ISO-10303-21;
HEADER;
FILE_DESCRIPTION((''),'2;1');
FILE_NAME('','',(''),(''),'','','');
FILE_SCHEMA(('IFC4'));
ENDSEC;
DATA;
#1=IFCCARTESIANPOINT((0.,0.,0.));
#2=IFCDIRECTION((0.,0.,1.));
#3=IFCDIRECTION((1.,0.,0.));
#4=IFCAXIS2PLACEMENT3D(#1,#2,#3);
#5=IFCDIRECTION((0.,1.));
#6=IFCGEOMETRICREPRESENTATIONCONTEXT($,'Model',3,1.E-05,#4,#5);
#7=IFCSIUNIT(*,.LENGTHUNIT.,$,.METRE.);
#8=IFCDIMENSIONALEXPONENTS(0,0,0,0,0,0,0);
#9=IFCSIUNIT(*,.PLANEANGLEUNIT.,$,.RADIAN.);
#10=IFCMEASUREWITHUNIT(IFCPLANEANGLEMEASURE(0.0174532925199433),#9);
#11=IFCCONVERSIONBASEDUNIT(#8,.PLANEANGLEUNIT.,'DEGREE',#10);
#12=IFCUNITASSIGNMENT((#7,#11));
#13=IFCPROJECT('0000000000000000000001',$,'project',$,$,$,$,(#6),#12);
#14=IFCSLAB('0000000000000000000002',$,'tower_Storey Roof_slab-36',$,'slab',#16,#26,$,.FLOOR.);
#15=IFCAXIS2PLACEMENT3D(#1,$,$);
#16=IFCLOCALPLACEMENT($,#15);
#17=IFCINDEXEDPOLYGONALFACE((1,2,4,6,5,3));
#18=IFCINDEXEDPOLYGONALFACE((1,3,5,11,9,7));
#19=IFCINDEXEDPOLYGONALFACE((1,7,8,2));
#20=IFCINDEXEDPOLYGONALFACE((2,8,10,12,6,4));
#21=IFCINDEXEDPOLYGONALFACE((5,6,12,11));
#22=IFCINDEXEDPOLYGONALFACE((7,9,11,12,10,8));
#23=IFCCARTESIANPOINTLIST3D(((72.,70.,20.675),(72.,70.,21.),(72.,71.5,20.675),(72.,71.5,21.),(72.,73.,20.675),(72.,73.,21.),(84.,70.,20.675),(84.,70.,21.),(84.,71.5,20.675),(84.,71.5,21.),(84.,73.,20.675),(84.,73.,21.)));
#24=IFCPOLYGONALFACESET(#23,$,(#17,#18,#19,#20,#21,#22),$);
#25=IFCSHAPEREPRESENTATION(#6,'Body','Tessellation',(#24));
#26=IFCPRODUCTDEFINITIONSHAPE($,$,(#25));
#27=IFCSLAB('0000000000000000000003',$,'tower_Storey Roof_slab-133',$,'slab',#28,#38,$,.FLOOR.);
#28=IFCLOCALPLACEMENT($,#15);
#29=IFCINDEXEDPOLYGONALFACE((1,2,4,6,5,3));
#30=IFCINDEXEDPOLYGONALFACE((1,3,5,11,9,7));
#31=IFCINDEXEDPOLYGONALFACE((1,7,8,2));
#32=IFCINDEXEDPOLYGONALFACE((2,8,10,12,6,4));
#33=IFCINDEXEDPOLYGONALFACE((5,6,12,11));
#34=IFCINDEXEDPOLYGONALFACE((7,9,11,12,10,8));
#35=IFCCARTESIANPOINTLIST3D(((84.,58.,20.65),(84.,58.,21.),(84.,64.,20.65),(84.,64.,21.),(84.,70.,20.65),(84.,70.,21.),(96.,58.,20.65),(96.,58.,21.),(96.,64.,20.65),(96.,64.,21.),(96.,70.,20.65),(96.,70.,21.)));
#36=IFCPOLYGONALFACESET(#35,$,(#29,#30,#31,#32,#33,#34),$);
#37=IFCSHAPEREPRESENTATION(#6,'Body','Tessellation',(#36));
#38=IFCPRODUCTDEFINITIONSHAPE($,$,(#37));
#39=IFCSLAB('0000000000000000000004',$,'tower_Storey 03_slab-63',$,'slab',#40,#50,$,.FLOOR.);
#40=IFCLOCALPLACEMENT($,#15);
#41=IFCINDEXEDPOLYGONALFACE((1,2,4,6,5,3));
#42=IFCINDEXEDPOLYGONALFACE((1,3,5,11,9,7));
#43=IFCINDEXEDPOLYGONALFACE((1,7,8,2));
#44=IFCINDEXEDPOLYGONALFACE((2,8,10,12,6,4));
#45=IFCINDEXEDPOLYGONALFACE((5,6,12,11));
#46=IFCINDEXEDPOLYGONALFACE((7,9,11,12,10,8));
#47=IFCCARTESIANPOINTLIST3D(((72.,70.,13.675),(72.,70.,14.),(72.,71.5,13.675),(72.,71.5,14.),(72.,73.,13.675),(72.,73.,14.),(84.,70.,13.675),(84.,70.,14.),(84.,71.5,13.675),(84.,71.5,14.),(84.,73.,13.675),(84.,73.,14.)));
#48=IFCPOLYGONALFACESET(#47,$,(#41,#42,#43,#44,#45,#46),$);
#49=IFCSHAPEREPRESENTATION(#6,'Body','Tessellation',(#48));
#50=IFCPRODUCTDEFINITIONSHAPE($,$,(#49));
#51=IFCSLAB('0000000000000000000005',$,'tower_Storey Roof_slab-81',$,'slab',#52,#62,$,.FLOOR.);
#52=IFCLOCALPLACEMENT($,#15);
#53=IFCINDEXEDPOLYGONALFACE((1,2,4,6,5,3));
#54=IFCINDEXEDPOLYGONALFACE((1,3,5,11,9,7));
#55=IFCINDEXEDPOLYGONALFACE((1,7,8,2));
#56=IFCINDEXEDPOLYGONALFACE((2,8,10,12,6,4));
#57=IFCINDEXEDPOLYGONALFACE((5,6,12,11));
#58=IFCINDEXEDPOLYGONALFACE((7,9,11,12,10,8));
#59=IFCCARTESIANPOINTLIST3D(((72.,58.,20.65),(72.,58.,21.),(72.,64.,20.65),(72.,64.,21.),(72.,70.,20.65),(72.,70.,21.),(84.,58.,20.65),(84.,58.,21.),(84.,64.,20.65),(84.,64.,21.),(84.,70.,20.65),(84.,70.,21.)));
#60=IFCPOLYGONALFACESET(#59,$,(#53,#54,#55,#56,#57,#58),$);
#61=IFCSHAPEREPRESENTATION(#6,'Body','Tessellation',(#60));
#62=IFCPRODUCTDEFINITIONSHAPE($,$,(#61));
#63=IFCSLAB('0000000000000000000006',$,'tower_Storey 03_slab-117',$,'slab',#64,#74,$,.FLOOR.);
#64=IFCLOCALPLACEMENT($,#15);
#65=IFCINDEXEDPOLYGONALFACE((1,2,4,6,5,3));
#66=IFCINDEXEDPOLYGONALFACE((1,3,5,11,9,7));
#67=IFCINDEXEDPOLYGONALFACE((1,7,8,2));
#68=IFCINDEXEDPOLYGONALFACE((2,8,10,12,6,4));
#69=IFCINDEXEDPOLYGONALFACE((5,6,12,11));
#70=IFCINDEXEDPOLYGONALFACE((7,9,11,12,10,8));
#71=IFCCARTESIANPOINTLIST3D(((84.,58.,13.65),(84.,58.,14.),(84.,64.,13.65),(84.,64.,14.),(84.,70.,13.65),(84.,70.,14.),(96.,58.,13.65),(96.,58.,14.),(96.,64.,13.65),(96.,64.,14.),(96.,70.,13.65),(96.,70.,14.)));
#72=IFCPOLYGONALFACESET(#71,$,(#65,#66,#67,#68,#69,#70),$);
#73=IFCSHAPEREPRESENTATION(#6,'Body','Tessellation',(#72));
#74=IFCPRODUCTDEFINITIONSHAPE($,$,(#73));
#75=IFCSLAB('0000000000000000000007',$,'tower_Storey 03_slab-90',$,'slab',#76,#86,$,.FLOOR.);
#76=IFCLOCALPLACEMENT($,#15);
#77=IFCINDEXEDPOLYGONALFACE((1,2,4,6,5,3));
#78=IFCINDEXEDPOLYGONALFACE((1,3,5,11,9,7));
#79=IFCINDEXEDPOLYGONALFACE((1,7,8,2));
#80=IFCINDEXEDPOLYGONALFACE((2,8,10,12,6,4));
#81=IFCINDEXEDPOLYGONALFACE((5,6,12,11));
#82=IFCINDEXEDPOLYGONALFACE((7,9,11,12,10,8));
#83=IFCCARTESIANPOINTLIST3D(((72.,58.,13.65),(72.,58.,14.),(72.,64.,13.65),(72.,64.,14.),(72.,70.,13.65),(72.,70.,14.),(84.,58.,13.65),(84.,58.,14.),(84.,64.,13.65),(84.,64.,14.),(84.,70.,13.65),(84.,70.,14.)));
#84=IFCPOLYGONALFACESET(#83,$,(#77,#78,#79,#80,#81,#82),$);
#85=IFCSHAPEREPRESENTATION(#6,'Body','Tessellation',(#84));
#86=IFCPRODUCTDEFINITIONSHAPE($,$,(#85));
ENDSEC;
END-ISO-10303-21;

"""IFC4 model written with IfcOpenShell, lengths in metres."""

from ifc_helpers import new_model, entity, si_unit, converted_unit, direction, frame, origin_with_axes, place, context, project, polyline, outline, extrude, element, save


model = new_model("IFC4")

# Units and contexts
model_context = context("Model", 3, precision=1e-05, world=origin_with_axes(), true_north=direction((0.0, 1.0)))
ifc_project = project(units=[si_unit("LENGTHUNIT", "METRE"), converted_unit("PLANEANGLEUNIT", "DEGREE", entity("IfcPlaneAngleMeasure", 0.0174532925199433), si_unit("PLANEANGLEUNIT", "RADIAN"), dimensions=[0, 0, 0, 0, 0, 0, 0])], contexts=[model_context])

# Shared definitions
placement_1 = place(None, origin_with_axes())
placement_2 = place(placement_1, frame((0.0, 0.0, 14.0), z_axis=(0.0, 0.0, 1.0), x_axis=(1.0, 0.0, 0.0)))

# Shared definitions
placement_3 = place(placement_1, frame((0.0, 0.0, 21.0), z_axis=(0.0, 0.0, 1.0), x_axis=(1.0, 0.0, 0.0)))

# Slabs
slab_1_placement = place(placement_3, frame((78.0, 71.5, -0.325), z_axis=(0.0, 0.0, 1.0), x_axis=(1.0, 0.0, 0.0)))
element("IfcSlab", 1, at=slab_1_placement, Name="tower_Storey Roof_slab-36", ObjectType="slab", PredefinedType="FLOOR", context=model_context, body=[
    extrude(outline(polyline([(-6.0, -1.5, 0.0), (6.0, -1.5, 0.0), (6.0, 0.0, 0.0), (6.0, 1.5, 0.0), (-6.0, 1.5, 0.0), (-6.0, 0.0, 0.0), (-6.0, -1.5, 0.0)])), origin_with_axes(), (0.0, 0.0, 1.0), 0.325),
])
slab_2_placement = place(placement_3, frame((90.0, 64.0, -0.35), z_axis=(0.0, 0.0, 1.0), x_axis=(1.0, 0.0, 0.0)))
element("IfcSlab", 2, at=slab_2_placement, Name="tower_Storey Roof_slab-133", ObjectType="slab", PredefinedType="FLOOR", context=model_context, body=[
    extrude(outline(polyline([(-6.0, 0.0, 0.0), (-6.0, -6.0, 0.0), (6.0, -6.0, 0.0), (6.0, 0.0, 0.0), (6.0, 6.0, 0.0), (-6.0, 6.0, 0.0), (-6.0, 0.0, 0.0)])), origin_with_axes(), (0.0, 0.0, 1.0), 0.35),
])
slab_3_placement = place(placement_2, frame((78.0, 71.5, -0.325), z_axis=(0.0, 0.0, 1.0), x_axis=(1.0, 0.0, 0.0)))
element("IfcSlab", 3, at=slab_3_placement, Name="tower_Storey 03_slab-63", ObjectType="slab", PredefinedType="FLOOR", context=model_context, body=[
    extrude(outline(polyline([(-6.0, -1.5, 0.0), (6.0, -1.5, 0.0), (6.0, 0.0, 0.0), (6.0, 1.5, 0.0), (-6.0, 1.5, 0.0), (-6.0, 0.0, 0.0), (-6.0, -1.5, 0.0)])), origin_with_axes(), (0.0, 0.0, 1.0), 0.325),
])
slab_4_placement = place(placement_3, frame((78.0, 64.0, -0.35), z_axis=(0.0, 0.0, 1.0), x_axis=(1.0, 0.0, 0.0)))
element("IfcSlab", 4, at=slab_4_placement, Name="tower_Storey Roof_slab-81", ObjectType="slab", PredefinedType="FLOOR", context=model_context, body=[
    extrude(outline(polyline([(-6.0, -6.0, 0.0), (6.0, -6.0, 0.0), (6.0, 0.0, 0.0), (6.0, 6.0, 0.0), (-6.0, 6.0, 0.0), (-6.0, 0.0, 0.0), (-6.0, -6.0, 0.0)])), origin_with_axes(), (0.0, 0.0, 1.0), 0.35),
])
slab_5_placement = place(placement_2, frame((90.0, 64.0, -0.35), z_axis=(0.0, 0.0, 1.0), x_axis=(1.0, 0.0, 0.0)))
element("IfcSlab", 5, at=slab_5_placement, Name="tower_Storey 03_slab-117", ObjectType="slab", PredefinedType="FLOOR", context=model_context, body=[
    extrude(outline(polyline([(-6.0, 0.0, 0.0), (-6.0, -6.0, 0.0), (6.0, -6.0, 0.0), (6.0, 0.0, 0.0), (6.0, 6.0, 0.0), (-6.0, 6.0, 0.0), (-6.0, 0.0, 0.0)])), origin_with_axes(), (0.0, 0.0, 1.0), 0.35),
])
slab_6_placement = place(placement_2, frame((78.0, 64.0, -0.35), z_axis=(0.0, 0.0, 1.0), x_axis=(1.0, 0.0, 0.0)))
element("IfcSlab", 6, at=slab_6_placement, Name="tower_Storey 03_slab-90", ObjectType="slab", PredefinedType="FLOOR", context=model_context, body=[
    extrude(outline(polyline([(-6.0, -6.0, 0.0), (6.0, -6.0, 0.0), (6.0, 0.0, 0.0), (6.0, 6.0, 0.0), (-6.0, 6.0, 0.0), (-6.0, 0.0, 0.0), (-6.0, -6.0, 0.0)])), origin_with_axes(), (0.0, 0.0, 1.0), 0.35),
])

save(model, "model.ifc")
